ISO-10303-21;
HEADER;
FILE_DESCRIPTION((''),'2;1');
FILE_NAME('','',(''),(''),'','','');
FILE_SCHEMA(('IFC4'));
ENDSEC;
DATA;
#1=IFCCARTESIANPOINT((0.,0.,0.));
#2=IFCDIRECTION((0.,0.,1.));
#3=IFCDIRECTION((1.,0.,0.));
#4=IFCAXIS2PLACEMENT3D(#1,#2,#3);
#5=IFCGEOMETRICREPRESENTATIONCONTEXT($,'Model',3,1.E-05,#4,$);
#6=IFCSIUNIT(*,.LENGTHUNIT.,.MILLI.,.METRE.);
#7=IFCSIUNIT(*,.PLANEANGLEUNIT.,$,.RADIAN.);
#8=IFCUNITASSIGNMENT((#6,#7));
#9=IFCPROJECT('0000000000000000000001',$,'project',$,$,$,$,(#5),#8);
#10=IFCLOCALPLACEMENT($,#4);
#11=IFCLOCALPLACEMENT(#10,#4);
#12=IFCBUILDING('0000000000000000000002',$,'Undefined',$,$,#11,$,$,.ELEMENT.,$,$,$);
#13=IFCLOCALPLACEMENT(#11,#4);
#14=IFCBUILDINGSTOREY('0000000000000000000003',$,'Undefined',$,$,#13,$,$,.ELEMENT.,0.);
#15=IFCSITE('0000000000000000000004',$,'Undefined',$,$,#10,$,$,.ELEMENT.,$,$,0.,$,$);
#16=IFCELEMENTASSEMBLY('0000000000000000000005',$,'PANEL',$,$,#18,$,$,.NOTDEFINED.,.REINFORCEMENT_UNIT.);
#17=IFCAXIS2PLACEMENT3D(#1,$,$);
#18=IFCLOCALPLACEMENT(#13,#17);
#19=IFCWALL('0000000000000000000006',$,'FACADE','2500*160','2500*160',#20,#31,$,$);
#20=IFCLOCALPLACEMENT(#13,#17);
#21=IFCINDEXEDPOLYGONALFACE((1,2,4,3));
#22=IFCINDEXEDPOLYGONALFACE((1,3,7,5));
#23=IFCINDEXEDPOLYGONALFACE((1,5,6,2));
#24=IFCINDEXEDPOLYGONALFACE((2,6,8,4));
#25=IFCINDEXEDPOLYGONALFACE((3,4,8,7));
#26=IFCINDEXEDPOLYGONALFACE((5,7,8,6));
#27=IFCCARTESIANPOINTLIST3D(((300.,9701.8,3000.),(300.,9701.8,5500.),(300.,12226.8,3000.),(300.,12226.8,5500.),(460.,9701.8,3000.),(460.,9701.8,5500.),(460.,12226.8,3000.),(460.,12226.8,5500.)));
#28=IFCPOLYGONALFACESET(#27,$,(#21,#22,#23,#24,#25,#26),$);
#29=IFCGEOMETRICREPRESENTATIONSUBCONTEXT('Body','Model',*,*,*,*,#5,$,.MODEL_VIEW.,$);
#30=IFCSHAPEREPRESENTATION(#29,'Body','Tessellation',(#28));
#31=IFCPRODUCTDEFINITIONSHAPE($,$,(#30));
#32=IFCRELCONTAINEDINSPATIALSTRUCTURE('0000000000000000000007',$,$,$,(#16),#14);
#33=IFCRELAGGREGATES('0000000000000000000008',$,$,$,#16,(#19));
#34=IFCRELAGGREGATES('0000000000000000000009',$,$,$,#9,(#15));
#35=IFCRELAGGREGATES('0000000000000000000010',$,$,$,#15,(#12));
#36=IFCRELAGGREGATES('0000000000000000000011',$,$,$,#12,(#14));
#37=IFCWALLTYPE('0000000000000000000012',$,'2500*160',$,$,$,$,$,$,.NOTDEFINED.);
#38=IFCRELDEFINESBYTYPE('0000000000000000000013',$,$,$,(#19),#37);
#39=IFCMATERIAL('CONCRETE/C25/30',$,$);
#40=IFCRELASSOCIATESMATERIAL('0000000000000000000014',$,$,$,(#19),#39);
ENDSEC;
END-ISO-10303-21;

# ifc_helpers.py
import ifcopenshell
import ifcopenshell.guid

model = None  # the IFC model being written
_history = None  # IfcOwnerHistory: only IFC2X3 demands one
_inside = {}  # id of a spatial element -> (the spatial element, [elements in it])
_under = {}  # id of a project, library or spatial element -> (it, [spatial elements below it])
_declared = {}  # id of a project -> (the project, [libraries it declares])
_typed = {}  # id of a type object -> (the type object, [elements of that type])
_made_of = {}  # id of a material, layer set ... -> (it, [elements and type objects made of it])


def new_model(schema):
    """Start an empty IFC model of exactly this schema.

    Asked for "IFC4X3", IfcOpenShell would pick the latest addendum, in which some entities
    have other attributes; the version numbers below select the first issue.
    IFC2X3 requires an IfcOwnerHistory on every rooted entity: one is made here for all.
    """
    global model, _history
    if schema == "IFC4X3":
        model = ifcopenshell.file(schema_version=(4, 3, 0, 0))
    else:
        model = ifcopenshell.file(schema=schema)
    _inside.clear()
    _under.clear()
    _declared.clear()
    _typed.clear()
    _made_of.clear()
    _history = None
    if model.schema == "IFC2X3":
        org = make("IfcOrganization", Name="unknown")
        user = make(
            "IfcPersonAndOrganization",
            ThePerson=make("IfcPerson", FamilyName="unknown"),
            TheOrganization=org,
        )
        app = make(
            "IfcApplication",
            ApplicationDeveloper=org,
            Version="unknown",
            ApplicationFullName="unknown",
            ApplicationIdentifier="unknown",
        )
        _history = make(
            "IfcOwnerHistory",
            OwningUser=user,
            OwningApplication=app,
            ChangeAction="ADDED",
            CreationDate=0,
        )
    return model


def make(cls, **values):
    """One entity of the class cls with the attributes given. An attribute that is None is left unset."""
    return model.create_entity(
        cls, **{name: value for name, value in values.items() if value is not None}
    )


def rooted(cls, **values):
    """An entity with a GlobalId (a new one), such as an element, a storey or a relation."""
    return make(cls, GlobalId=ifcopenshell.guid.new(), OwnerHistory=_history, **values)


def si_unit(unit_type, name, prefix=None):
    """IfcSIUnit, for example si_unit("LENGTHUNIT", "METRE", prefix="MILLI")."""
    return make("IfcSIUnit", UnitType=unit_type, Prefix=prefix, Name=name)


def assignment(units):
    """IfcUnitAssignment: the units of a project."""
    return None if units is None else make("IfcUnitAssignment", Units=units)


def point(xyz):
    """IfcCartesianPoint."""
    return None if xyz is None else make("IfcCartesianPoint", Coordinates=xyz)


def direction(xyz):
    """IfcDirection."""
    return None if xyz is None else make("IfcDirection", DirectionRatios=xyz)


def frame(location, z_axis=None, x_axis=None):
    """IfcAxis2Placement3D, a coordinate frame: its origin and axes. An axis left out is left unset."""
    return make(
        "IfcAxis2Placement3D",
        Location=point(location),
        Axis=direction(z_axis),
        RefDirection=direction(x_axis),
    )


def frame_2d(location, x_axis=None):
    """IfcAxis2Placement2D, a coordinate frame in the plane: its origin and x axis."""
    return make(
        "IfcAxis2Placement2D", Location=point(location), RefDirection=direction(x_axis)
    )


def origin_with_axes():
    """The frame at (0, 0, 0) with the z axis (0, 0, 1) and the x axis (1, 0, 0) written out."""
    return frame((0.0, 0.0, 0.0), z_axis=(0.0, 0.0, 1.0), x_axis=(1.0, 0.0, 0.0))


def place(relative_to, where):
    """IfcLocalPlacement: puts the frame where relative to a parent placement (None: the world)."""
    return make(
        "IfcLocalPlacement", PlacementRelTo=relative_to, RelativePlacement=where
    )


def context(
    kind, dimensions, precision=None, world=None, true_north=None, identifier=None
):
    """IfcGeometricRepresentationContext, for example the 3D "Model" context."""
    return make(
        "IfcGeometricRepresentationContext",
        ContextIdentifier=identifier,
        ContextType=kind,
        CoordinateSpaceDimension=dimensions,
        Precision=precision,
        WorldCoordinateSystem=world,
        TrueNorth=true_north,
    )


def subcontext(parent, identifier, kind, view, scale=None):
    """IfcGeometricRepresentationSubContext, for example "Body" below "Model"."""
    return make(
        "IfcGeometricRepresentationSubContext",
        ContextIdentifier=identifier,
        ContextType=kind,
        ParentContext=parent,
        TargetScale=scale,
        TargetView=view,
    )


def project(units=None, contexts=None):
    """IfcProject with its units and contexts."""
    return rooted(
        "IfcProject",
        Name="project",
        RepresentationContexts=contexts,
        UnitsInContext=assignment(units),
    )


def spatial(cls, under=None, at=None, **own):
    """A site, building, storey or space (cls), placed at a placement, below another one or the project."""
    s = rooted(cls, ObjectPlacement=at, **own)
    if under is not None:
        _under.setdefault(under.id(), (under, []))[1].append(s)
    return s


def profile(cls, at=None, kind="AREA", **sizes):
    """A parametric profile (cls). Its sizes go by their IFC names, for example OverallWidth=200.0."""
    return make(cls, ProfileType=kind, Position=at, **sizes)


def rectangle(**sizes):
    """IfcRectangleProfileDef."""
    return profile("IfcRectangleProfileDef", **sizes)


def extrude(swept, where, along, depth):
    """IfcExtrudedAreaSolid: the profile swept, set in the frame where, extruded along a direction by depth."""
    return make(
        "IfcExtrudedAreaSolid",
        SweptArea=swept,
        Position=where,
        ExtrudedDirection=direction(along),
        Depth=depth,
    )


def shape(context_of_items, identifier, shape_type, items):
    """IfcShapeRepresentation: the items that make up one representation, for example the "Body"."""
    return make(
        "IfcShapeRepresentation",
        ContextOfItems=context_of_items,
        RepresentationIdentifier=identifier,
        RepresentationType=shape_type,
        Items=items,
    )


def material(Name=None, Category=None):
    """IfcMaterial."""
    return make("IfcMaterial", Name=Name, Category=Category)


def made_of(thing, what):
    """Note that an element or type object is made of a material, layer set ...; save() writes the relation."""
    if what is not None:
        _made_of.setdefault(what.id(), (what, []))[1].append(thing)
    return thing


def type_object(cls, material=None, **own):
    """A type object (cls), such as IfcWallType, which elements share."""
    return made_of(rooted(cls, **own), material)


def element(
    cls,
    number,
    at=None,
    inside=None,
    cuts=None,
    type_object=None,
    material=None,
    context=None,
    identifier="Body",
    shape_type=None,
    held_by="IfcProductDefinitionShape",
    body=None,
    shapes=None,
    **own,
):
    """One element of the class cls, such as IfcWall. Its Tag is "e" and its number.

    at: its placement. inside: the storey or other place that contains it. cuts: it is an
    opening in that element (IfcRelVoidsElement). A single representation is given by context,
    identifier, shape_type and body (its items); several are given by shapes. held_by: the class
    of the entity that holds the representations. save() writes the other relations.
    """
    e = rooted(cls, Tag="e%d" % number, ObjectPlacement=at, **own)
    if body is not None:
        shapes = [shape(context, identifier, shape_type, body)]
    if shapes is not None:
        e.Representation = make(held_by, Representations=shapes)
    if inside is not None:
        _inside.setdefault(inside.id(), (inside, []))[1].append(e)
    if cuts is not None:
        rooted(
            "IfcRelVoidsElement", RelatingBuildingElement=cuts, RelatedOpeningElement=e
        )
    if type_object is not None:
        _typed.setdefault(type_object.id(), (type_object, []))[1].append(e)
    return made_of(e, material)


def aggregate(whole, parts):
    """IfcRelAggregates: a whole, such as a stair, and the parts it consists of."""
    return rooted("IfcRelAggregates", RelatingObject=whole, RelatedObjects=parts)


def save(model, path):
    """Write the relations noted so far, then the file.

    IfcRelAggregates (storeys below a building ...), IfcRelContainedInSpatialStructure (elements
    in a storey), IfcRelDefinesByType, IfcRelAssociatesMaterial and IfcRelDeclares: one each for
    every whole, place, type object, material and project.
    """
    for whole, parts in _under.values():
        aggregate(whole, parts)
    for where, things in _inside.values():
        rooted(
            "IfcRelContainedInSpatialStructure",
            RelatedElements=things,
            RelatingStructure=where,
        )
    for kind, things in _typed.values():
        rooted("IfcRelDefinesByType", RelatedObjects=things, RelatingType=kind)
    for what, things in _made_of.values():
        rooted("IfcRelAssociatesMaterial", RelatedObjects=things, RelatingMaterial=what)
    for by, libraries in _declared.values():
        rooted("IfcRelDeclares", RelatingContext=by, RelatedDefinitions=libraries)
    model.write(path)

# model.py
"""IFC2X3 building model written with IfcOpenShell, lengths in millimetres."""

from ifc_helpers import new_model, si_unit, frame, frame_2d, origin_with_axes, place, context, subcontext, project, spatial, rectangle, extrude, material, type_object, element, aggregate, save


model = new_model("IFC2X3")

# Units and contexts
model_context = context("Model", 3, precision=1e-05, world=origin_with_axes())
body_context = subcontext(model_context, "Body", "Model", "MODEL_VIEW")
ifc_project = project(units=[si_unit("LENGTHUNIT", "METRE", prefix="MILLI"), si_unit("PLANEANGLEUNIT", "RADIAN")], contexts=[model_context])

# Site, building, storey
site_placement = place(None, origin_with_axes())
site = spatial("IfcSite", under=ifc_project, at=site_placement, Name="Undefined", CompositionType="ELEMENT", RefElevation=0.0)
building_placement = place(site_placement, origin_with_axes())
building = spatial("IfcBuilding", under=site, at=building_placement, Name="Undefined", CompositionType="ELEMENT")
storey_placement = place(building_placement, origin_with_axes())
storey = spatial("IfcBuildingStorey", under=building, at=storey_placement, Name="Undefined", CompositionType="ELEMENT", Elevation=0.0)

# Shared definitions
ifc_material = material(Name="CONCRETE/C25/30")

# Element assembly, wall
wall_type_1 = type_object("IfcWallType", Name="2500*160", PredefinedType="NOTDEFINED")
assembly_1_placement = place(storey_placement, origin_with_axes())
assembly_1 = element("IfcElementAssembly", 1, at=assembly_1_placement, inside=storey, Name="PANEL", AssemblyPlace="NOTDEFINED", PredefinedType="REINFORCEMENT_UNIT")
wall_1_placement = place(assembly_1_placement, frame((380.0, 12226.8, 3000.0), z_axis=(0.0, 0.0, 1.0), x_axis=(0.0, -1.0, 0.0)))
wall_1 = element("IfcWall", 2, at=wall_1_placement, type_object=wall_type_1, material=ifc_material, Name="FACADE", Description="2500*160", ObjectType="2500*160", context=body_context, shape_type="SweptSolid", body=[
    extrude(rectangle(XDim=2525.0, YDim=160.0, at=frame_2d((0.0, 1262.5), x_axis=(0.0, -1.0))), frame((0.0, 0.0, 0.0), z_axis=(0.0, 0.0, 1.0), x_axis=(0.0, -1.0, 0.0)), (0.0, 0.0, 1.0), 2500.0),
])
aggregate(assembly_1, [wall_1])

save(model, "model.ifc")
